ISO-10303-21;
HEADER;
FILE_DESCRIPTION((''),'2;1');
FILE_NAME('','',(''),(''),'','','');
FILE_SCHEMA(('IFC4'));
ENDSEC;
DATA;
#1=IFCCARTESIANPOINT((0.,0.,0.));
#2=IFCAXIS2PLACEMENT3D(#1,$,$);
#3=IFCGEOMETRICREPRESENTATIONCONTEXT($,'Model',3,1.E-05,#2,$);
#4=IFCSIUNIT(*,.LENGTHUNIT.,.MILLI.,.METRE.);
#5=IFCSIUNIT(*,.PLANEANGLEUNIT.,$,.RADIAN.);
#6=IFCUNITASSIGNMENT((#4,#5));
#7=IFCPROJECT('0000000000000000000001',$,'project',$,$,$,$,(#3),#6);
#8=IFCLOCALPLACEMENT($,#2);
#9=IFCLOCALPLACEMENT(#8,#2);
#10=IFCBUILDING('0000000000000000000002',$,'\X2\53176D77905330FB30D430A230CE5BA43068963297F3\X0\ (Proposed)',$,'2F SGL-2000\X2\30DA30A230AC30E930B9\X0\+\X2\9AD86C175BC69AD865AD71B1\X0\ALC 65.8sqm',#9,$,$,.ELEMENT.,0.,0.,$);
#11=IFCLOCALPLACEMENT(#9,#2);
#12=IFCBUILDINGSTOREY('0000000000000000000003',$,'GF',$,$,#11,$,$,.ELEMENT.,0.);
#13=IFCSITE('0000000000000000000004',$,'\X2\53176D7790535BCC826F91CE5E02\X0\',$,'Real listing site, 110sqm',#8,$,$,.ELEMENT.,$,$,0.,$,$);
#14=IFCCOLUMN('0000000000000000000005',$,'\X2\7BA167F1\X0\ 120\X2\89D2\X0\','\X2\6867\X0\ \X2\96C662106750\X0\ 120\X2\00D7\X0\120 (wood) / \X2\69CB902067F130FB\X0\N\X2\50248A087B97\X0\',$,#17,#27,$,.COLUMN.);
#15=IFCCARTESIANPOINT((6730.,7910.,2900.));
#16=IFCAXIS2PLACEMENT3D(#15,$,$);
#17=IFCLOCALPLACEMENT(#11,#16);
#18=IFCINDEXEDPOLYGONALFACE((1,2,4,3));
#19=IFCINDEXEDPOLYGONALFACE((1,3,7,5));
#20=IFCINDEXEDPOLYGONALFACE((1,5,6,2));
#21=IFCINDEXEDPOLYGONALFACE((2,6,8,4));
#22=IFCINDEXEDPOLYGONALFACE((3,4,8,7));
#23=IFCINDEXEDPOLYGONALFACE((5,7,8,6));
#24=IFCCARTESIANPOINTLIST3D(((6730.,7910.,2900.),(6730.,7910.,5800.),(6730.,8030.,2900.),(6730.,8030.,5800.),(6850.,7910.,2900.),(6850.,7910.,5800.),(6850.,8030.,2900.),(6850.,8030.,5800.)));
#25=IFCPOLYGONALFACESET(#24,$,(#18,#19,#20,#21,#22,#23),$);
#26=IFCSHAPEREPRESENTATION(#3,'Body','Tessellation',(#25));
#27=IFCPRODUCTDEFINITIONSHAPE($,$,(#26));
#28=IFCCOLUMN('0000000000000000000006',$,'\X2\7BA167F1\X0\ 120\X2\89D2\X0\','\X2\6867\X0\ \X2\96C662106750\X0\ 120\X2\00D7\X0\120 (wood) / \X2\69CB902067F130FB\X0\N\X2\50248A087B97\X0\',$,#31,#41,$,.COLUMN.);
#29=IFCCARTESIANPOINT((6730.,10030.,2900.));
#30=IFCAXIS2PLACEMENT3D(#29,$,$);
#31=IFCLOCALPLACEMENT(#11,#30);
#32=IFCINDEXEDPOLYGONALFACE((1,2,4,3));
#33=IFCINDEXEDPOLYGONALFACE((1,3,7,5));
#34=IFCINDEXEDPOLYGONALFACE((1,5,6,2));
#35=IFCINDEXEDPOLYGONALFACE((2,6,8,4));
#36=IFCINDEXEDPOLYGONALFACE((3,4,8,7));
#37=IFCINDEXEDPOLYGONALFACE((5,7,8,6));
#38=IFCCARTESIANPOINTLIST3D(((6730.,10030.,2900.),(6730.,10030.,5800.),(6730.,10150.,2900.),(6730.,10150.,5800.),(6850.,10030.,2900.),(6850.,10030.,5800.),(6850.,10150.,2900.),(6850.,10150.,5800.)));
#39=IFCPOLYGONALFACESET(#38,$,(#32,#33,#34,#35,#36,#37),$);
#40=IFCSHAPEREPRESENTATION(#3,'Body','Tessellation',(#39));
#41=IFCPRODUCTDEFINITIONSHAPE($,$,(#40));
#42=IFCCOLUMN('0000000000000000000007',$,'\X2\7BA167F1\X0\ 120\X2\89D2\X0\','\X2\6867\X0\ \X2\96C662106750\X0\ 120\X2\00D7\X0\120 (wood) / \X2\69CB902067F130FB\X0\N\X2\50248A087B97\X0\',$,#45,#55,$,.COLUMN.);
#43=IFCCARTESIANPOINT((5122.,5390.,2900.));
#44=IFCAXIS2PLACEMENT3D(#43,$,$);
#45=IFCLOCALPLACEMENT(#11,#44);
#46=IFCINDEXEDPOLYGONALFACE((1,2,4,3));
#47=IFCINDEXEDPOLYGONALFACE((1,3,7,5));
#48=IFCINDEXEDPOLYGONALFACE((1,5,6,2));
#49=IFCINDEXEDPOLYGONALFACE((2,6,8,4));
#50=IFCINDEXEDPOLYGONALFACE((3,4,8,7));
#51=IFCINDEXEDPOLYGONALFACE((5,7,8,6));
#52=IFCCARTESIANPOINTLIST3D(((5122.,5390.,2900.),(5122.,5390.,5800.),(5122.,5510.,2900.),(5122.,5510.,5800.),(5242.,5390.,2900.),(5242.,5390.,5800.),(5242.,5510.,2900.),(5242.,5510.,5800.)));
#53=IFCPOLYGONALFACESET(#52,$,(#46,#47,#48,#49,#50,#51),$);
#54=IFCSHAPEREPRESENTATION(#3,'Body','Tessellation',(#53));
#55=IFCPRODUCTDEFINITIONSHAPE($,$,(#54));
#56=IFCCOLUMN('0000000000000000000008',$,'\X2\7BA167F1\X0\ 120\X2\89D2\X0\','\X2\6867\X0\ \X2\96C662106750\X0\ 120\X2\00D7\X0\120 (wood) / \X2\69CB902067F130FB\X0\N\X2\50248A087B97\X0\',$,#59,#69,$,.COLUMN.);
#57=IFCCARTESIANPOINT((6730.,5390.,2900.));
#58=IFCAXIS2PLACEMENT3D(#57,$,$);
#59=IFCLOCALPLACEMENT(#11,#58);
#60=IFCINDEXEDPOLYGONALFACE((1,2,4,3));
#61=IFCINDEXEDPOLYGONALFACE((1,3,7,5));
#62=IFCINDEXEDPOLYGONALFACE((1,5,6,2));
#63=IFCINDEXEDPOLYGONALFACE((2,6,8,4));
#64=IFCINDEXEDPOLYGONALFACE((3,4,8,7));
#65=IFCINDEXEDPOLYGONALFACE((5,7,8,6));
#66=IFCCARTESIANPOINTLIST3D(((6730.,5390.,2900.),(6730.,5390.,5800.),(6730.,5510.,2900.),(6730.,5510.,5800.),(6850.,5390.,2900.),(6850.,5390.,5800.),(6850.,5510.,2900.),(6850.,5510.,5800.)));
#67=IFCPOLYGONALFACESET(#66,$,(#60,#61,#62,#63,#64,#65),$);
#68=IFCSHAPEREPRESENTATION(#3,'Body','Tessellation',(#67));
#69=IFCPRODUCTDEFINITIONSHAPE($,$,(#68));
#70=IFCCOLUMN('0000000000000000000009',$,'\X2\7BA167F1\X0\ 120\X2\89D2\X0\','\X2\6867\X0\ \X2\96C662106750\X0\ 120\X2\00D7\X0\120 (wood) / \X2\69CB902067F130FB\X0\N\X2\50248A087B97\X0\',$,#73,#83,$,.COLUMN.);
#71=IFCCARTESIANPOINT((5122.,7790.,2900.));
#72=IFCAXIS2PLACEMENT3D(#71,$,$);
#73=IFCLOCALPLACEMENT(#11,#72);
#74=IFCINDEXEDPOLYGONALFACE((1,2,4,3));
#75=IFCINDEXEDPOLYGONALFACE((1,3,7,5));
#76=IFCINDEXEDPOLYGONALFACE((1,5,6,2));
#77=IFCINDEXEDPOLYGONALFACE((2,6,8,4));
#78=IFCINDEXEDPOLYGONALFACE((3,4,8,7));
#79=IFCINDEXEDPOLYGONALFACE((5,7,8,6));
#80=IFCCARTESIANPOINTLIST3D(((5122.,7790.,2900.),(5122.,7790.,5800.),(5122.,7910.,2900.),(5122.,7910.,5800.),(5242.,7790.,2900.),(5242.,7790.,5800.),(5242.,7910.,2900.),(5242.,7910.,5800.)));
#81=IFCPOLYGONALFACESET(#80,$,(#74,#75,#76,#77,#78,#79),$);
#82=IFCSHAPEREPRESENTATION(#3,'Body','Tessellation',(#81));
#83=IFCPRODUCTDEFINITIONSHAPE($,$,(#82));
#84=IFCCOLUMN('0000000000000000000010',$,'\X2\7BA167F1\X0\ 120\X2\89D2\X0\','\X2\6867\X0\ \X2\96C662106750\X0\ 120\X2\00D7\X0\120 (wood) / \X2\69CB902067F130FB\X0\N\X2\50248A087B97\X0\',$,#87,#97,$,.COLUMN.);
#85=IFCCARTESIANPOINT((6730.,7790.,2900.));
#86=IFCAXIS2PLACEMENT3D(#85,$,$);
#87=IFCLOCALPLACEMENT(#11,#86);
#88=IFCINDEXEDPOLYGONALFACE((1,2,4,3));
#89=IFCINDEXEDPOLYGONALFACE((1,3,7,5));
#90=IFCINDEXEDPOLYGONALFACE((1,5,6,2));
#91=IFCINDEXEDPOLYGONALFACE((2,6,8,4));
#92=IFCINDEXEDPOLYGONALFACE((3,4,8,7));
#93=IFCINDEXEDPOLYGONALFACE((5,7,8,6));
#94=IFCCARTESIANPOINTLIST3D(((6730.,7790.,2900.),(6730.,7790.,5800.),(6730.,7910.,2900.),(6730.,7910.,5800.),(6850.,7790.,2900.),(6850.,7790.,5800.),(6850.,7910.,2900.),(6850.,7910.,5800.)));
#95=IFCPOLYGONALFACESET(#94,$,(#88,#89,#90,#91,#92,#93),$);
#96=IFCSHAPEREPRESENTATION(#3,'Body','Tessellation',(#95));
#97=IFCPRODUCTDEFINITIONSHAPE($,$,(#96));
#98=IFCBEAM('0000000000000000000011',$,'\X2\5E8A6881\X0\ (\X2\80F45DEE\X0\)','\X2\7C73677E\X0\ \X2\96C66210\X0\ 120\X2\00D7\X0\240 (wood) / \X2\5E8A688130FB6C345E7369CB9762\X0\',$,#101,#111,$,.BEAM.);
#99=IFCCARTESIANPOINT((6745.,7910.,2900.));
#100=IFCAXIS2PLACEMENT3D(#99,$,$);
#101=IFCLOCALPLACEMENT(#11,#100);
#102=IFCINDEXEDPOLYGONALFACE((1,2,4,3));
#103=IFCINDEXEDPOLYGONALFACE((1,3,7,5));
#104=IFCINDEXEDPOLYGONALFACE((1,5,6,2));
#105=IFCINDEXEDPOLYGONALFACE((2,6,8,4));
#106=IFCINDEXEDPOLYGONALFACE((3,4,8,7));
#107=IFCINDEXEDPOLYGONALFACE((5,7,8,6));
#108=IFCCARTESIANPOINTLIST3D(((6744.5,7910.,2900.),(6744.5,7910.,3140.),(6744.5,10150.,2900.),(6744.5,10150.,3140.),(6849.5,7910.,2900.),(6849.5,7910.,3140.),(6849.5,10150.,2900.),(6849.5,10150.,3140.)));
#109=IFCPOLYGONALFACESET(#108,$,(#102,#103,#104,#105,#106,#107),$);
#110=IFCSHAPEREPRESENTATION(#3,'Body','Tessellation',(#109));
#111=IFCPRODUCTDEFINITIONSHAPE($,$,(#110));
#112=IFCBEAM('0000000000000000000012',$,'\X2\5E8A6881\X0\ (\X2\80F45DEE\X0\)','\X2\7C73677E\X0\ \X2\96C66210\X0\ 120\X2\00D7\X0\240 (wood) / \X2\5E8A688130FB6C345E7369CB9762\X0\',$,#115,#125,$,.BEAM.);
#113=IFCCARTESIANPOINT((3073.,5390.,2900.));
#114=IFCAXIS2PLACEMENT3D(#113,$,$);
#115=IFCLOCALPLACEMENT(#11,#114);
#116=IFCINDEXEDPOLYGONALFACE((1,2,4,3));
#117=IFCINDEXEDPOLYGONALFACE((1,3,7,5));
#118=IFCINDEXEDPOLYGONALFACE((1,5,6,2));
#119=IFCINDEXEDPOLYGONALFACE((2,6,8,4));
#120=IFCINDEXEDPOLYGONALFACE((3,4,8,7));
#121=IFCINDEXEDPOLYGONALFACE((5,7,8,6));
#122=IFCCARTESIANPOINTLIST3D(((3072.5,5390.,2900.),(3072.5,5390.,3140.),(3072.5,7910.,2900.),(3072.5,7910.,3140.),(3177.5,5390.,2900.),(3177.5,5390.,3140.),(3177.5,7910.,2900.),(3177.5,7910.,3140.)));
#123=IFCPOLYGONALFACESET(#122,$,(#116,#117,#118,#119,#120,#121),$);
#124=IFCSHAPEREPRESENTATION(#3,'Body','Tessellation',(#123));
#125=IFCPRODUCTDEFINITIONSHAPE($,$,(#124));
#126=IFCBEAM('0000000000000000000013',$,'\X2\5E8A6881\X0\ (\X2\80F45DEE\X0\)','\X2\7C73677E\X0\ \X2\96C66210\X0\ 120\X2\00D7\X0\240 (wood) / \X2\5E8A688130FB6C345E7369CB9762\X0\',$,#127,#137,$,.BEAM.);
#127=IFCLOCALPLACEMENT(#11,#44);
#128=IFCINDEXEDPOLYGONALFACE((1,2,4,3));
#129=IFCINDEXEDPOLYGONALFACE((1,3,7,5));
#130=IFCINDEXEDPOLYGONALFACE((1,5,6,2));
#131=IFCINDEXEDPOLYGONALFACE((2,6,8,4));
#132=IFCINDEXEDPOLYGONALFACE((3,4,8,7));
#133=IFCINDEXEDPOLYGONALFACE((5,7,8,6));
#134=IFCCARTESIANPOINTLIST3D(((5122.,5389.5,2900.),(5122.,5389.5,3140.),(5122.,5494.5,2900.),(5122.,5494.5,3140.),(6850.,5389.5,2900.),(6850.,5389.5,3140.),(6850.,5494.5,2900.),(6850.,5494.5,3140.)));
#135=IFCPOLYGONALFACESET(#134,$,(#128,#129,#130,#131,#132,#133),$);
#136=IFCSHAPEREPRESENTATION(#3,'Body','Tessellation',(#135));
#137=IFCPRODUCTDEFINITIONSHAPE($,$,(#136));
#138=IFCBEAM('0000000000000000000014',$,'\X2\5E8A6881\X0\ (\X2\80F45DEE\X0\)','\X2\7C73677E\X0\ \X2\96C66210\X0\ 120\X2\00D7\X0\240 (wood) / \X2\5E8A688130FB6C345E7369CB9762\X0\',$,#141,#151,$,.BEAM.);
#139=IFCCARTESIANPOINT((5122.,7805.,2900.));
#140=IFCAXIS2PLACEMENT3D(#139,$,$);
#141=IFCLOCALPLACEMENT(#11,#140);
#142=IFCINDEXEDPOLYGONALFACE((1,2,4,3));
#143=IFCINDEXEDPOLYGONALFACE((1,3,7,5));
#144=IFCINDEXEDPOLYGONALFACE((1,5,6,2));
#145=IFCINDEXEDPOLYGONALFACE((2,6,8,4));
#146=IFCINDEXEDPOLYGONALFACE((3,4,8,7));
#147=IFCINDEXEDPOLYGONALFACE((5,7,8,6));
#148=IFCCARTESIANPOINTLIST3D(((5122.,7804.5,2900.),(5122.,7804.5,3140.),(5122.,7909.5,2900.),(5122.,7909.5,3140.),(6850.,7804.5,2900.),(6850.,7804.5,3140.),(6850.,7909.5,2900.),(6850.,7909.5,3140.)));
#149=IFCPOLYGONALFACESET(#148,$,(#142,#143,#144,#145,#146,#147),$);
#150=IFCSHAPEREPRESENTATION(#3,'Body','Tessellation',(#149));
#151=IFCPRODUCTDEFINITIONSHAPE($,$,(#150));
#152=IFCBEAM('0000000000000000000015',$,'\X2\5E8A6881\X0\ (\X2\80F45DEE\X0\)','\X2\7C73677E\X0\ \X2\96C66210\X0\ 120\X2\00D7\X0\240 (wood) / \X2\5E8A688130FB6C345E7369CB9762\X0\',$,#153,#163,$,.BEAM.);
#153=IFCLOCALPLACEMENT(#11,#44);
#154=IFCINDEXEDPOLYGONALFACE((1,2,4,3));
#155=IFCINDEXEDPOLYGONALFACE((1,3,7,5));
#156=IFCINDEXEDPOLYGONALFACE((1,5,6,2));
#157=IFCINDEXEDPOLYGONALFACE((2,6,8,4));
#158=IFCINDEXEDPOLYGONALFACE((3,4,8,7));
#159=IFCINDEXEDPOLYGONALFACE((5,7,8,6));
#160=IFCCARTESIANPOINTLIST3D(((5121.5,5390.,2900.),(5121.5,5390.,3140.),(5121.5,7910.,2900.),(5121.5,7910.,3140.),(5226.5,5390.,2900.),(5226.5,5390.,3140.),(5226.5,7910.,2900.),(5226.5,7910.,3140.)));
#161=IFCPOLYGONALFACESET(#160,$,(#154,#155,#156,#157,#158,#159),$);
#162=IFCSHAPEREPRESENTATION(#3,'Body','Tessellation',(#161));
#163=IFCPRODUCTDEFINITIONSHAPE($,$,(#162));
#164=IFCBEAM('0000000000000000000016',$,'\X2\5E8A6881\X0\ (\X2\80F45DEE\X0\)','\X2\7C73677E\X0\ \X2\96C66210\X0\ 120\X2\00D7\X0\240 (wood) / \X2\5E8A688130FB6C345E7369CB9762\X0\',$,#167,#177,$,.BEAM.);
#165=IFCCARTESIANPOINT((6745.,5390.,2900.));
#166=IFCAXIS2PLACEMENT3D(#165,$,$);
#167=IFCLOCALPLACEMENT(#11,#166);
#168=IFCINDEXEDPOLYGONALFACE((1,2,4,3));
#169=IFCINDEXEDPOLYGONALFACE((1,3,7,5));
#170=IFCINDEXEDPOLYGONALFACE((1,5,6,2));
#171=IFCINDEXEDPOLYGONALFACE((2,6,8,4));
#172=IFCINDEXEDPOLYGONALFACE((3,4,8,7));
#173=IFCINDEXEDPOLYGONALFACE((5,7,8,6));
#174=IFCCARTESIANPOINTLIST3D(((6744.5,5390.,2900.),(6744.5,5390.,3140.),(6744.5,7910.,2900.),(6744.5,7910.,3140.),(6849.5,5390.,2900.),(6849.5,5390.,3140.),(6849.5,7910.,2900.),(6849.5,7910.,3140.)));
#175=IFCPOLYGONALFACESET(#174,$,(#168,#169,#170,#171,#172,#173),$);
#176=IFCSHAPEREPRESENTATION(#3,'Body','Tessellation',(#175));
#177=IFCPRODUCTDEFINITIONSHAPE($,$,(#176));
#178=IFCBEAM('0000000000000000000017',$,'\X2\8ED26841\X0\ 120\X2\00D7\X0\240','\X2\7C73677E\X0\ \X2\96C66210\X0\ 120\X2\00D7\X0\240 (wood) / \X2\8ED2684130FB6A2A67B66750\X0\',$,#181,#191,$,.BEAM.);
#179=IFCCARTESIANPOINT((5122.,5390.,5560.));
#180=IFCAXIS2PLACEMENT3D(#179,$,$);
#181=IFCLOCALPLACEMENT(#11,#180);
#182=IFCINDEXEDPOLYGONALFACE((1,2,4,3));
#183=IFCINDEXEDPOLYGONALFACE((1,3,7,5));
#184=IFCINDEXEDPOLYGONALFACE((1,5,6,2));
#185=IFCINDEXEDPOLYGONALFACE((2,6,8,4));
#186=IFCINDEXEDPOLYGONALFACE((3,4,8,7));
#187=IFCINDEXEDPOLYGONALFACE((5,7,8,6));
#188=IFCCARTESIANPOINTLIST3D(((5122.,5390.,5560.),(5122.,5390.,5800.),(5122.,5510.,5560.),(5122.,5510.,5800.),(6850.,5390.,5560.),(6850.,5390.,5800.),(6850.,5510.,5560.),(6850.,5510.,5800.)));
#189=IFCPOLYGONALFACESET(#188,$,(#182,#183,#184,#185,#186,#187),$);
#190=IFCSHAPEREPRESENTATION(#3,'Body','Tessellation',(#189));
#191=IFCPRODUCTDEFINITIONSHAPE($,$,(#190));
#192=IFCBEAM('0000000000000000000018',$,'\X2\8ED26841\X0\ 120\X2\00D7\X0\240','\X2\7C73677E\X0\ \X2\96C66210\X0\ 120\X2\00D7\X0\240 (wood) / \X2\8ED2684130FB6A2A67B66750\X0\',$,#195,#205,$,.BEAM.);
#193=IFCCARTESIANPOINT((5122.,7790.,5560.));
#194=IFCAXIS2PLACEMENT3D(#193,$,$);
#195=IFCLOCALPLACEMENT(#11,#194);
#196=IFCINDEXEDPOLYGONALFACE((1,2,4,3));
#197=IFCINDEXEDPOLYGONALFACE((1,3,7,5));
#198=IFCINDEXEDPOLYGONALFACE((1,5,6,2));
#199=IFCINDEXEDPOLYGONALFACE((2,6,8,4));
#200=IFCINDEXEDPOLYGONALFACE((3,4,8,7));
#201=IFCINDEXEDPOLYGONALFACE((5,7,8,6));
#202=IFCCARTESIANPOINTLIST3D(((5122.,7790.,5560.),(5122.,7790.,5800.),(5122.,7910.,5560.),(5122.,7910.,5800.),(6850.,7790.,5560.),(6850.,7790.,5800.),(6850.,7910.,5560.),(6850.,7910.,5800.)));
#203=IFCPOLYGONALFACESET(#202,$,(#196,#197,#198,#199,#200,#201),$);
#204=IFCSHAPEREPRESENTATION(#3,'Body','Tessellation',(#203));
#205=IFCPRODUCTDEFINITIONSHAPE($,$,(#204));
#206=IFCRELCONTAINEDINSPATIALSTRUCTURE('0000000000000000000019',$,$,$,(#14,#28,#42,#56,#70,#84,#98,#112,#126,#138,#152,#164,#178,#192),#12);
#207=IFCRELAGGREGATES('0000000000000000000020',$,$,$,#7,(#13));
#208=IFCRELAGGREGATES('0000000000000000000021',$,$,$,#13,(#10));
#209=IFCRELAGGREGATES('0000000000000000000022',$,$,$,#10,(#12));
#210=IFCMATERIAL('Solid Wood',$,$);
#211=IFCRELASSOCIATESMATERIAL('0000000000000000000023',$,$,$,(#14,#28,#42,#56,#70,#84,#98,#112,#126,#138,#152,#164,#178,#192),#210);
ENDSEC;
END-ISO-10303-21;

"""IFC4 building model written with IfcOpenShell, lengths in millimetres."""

from ifc_helpers import new_model, si_unit, frame, frame_2d, origin, place, context, project, spatial, rectangle, extrude, material, element, save


model = new_model("IFC4")

# Units and contexts
model_context = context("Model", 3, precision=1e-05, world=origin())
ifc_project = project(units=[si_unit("LENGTHUNIT", "METRE", prefix="MILLI"), si_unit("PLANEANGLEUNIT", "RADIAN")], contexts=[model_context])

# Site, building, storey
site_placement = place(None, origin())
site = spatial("IfcSite", under=ifc_project, at=site_placement, Name="北海道富良野市", ObjectType="Real listing site, 110sqm", CompositionType="ELEMENT", RefElevation=0.0)
building_placement = place(site_placement, origin())
building = spatial("IfcBuilding", under=site, at=building_placement, Name="北海道・ピアノ室と防音 (Proposed)", ObjectType="2F SGL-2000ペアガラス+高気密高断熱ALC 65.8sqm", CompositionType="ELEMENT", ElevationOfRefHeight=0.0, ElevationOfTerrain=0.0)
storey_placement = place(building_placement, origin())
storey = spatial("IfcBuildingStorey", under=building, at=storey_placement, Name="GF", CompositionType="ELEMENT", Elevation=0.0)

# Columns
ifc_material_1 = material(Name="Solid Wood")
column_1_placement = place(storey_placement, frame((6730.0, 7910.0, 2900.0)))
element("IfcColumn", 1, at=column_1_placement, inside=storey, material=ifc_material_1, Name="管柱 120角", Description="桧 集成材 120×120 (wood) / 構造柱・N値計算", PredefinedType="COLUMN", context=model_context, shape_type="SweptSolid", body=[
    extrude(rectangle(XDim=120.0, YDim=120.0, at=frame_2d((60.0, 60.0))), frame((6730.0, 7910.0, 2900.0)), (0.0, 0.0, 1.0), 2900.0),
])
column_2_placement = place(storey_placement, frame((6730.0, 10030.0, 2900.0)))
element("IfcColumn", 2, at=column_2_placement, inside=storey, material=ifc_material_1, Name="管柱 120角", Description="桧 集成材 120×120 (wood) / 構造柱・N値計算", PredefinedType="COLUMN", context=model_context, shape_type="SweptSolid", body=[
    extrude(rectangle(XDim=120.0, YDim=120.0, at=frame_2d((60.0, 60.0))), frame((6730.0, 10030.0, 2900.0)), (0.0, 0.0, 1.0), 2900.0),
])
column_3_placement = place(storey_placement, frame((5122.0, 5390.0, 2900.0)))
element("IfcColumn", 3, at=column_3_placement, inside=storey, material=ifc_material_1, Name="管柱 120角", Description="桧 集成材 120×120 (wood) / 構造柱・N値計算", PredefinedType="COLUMN", context=model_context, shape_type="SweptSolid", body=[
    extrude(rectangle(XDim=120.0, YDim=120.0, at=frame_2d((60.0, 60.0))), frame((5122.0, 5390.0, 2900.0)), (0.0, 0.0, 1.0), 2900.0),
])
column_4_placement = place(storey_placement, frame((6730.0, 5390.0, 2900.0)))
element("IfcColumn", 4, at=column_4_placement, inside=storey, material=ifc_material_1, Name="管柱 120角", Description="桧 集成材 120×120 (wood) / 構造柱・N値計算", PredefinedType="COLUMN", context=model_context, shape_type="SweptSolid", body=[
    extrude(rectangle(XDim=120.0, YDim=120.0, at=frame_2d((60.0, 60.0))), frame((6730.0, 5390.0, 2900.0)), (0.0, 0.0, 1.0), 2900.0),
])
column_5_placement = place(storey_placement, frame((5122.0, 7790.0, 2900.0)))
element("IfcColumn", 5, at=column_5_placement, inside=storey, material=ifc_material_1, Name="管柱 120角", Description="桧 集成材 120×120 (wood) / 構造柱・N値計算", PredefinedType="COLUMN", context=model_context, shape_type="SweptSolid", body=[
    extrude(rectangle(XDim=120.0, YDim=120.0, at=frame_2d((60.0, 60.0))), frame((5122.0, 7790.0, 2900.0)), (0.0, 0.0, 1.0), 2900.0),
])
column_6_placement = place(storey_placement, frame((6730.0, 7790.0, 2900.0)))
element("IfcColumn", 6, at=column_6_placement, inside=storey, material=ifc_material_1, Name="管柱 120角", Description="桧 集成材 120×120 (wood) / 構造柱・N値計算", PredefinedType="COLUMN", context=model_context, shape_type="SweptSolid", body=[
    extrude(rectangle(XDim=120.0, YDim=120.0, at=frame_2d((60.0, 60.0))), frame((6730.0, 7790.0, 2900.0)), (0.0, 0.0, 1.0), 2900.0),
])

# Beams
beam_1_placement = place(storey_placement, frame((6745.0, 7910.0, 2900.0)))
element("IfcBeam", 7, at=beam_1_placement, inside=storey, material=ifc_material_1, Name="床梁 (胴差)", Description="米松 集成 120×240 (wood) / 床梁・水平構面", PredefinedType="BEAM", context=model_context, shape_type="SweptSolid", body=[
    extrude(rectangle(XDim=105.0, YDim=2240.0, at=frame_2d((52.0, 1120.0))), frame((6745.0, 7910.0, 2900.0)), (0.0, 0.0, 1.0), 240.0),
])
beam_2_placement = place(storey_placement, frame((3073.0, 5390.0, 2900.0)))
element("IfcBeam", 8, at=beam_2_placement, inside=storey, material=ifc_material_1, Name="床梁 (胴差)", Description="米松 集成 120×240 (wood) / 床梁・水平構面", PredefinedType="BEAM", context=model_context, shape_type="SweptSolid", body=[
    extrude(rectangle(XDim=105.0, YDim=2520.0, at=frame_2d((52.0, 1260.0))), frame((3073.0, 5390.0, 2900.0)), (0.0, 0.0, 1.0), 240.0),
])
beam_3_placement = place(storey_placement, frame((5122.0, 5390.0, 2900.0)))
element("IfcBeam", 9, at=beam_3_placement, inside=storey, material=ifc_material_1, Name="床梁 (胴差)", Description="米松 集成 120×240 (wood) / 床梁・水平構面", PredefinedType="BEAM", context=model_context, shape_type="SweptSolid", body=[
    extrude(rectangle(XDim=1728.0, YDim=105.0, at=frame_2d((864.0, 52.0))), frame((5122.0, 5390.0, 2900.0)), (0.0, 0.0, 1.0), 240.0),
])
beam_4_placement = place(storey_placement, frame((5122.0, 7805.0, 2900.0)))
element("IfcBeam", 10, at=beam_4_placement, inside=storey, material=ifc_material_1, Name="床梁 (胴差)", Description="米松 集成 120×240 (wood) / 床梁・水平構面", PredefinedType="BEAM", context=model_context, shape_type="SweptSolid", body=[
    extrude(rectangle(XDim=1728.0, YDim=105.0, at=frame_2d((864.0, 52.0))), frame((5122.0, 7805.0, 2900.0)), (0.0, 0.0, 1.0), 240.0),
])
beam_5_placement = place(storey_placement, frame((5122.0, 5390.0, 2900.0)))
element("IfcBeam", 11, at=beam_5_placement, inside=storey, material=ifc_material_1, Name="床梁 (胴差)", Description="米松 集成 120×240 (wood) / 床梁・水平構面", PredefinedType="BEAM", context=model_context, shape_type="SweptSolid", body=[
    extrude(rectangle(XDim=105.0, YDim=2520.0, at=frame_2d((52.0, 1260.0))), frame((5122.0, 5390.0, 2900.0)), (0.0, 0.0, 1.0), 240.0),
])
beam_6_placement = place(storey_placement, frame((6745.0, 5390.0, 2900.0)))
element("IfcBeam", 12, at=beam_6_placement, inside=storey, material=ifc_material_1, Name="床梁 (胴差)", Description="米松 集成 120×240 (wood) / 床梁・水平構面", PredefinedType="BEAM", context=model_context, shape_type="SweptSolid", body=[
    extrude(rectangle(XDim=105.0, YDim=2520.0, at=frame_2d((52.0, 1260.0))), frame((6745.0, 5390.0, 2900.0)), (0.0, 0.0, 1.0), 240.0),
])
beam_7_placement = place(storey_placement, frame((5122.0, 5390.0, 5560.0)))
element("IfcBeam", 13, at=beam_7_placement, inside=storey, material=ifc_material_1, Name="軒桁 120×240", Description="米松 集成 120×240 (wood) / 軒桁・横架材", PredefinedType="BEAM", context=model_context, shape_type="SweptSolid", body=[
    extrude(rectangle(XDim=1728.0, YDim=120.0, at=frame_2d((864.0, 60.0))), frame((5122.0, 5390.0, 5560.0)), (0.0, 0.0, 1.0), 240.0),
])
beam_8_placement = place(storey_placement, frame((5122.0, 7790.0, 5560.0)))
element("IfcBeam", 14, at=beam_8_placement, inside=storey, material=ifc_material_1, Name="軒桁 120×240", Description="米松 集成 120×240 (wood) / 軒桁・横架材", PredefinedType="BEAM", context=model_context, shape_type="SweptSolid", body=[
    extrude(rectangle(XDim=1728.0, YDim=120.0, at=frame_2d((864.0, 60.0))), frame((5122.0, 7790.0, 5560.0)), (0.0, 0.0, 1.0), 240.0),
])

save(model, "model.ifc")
